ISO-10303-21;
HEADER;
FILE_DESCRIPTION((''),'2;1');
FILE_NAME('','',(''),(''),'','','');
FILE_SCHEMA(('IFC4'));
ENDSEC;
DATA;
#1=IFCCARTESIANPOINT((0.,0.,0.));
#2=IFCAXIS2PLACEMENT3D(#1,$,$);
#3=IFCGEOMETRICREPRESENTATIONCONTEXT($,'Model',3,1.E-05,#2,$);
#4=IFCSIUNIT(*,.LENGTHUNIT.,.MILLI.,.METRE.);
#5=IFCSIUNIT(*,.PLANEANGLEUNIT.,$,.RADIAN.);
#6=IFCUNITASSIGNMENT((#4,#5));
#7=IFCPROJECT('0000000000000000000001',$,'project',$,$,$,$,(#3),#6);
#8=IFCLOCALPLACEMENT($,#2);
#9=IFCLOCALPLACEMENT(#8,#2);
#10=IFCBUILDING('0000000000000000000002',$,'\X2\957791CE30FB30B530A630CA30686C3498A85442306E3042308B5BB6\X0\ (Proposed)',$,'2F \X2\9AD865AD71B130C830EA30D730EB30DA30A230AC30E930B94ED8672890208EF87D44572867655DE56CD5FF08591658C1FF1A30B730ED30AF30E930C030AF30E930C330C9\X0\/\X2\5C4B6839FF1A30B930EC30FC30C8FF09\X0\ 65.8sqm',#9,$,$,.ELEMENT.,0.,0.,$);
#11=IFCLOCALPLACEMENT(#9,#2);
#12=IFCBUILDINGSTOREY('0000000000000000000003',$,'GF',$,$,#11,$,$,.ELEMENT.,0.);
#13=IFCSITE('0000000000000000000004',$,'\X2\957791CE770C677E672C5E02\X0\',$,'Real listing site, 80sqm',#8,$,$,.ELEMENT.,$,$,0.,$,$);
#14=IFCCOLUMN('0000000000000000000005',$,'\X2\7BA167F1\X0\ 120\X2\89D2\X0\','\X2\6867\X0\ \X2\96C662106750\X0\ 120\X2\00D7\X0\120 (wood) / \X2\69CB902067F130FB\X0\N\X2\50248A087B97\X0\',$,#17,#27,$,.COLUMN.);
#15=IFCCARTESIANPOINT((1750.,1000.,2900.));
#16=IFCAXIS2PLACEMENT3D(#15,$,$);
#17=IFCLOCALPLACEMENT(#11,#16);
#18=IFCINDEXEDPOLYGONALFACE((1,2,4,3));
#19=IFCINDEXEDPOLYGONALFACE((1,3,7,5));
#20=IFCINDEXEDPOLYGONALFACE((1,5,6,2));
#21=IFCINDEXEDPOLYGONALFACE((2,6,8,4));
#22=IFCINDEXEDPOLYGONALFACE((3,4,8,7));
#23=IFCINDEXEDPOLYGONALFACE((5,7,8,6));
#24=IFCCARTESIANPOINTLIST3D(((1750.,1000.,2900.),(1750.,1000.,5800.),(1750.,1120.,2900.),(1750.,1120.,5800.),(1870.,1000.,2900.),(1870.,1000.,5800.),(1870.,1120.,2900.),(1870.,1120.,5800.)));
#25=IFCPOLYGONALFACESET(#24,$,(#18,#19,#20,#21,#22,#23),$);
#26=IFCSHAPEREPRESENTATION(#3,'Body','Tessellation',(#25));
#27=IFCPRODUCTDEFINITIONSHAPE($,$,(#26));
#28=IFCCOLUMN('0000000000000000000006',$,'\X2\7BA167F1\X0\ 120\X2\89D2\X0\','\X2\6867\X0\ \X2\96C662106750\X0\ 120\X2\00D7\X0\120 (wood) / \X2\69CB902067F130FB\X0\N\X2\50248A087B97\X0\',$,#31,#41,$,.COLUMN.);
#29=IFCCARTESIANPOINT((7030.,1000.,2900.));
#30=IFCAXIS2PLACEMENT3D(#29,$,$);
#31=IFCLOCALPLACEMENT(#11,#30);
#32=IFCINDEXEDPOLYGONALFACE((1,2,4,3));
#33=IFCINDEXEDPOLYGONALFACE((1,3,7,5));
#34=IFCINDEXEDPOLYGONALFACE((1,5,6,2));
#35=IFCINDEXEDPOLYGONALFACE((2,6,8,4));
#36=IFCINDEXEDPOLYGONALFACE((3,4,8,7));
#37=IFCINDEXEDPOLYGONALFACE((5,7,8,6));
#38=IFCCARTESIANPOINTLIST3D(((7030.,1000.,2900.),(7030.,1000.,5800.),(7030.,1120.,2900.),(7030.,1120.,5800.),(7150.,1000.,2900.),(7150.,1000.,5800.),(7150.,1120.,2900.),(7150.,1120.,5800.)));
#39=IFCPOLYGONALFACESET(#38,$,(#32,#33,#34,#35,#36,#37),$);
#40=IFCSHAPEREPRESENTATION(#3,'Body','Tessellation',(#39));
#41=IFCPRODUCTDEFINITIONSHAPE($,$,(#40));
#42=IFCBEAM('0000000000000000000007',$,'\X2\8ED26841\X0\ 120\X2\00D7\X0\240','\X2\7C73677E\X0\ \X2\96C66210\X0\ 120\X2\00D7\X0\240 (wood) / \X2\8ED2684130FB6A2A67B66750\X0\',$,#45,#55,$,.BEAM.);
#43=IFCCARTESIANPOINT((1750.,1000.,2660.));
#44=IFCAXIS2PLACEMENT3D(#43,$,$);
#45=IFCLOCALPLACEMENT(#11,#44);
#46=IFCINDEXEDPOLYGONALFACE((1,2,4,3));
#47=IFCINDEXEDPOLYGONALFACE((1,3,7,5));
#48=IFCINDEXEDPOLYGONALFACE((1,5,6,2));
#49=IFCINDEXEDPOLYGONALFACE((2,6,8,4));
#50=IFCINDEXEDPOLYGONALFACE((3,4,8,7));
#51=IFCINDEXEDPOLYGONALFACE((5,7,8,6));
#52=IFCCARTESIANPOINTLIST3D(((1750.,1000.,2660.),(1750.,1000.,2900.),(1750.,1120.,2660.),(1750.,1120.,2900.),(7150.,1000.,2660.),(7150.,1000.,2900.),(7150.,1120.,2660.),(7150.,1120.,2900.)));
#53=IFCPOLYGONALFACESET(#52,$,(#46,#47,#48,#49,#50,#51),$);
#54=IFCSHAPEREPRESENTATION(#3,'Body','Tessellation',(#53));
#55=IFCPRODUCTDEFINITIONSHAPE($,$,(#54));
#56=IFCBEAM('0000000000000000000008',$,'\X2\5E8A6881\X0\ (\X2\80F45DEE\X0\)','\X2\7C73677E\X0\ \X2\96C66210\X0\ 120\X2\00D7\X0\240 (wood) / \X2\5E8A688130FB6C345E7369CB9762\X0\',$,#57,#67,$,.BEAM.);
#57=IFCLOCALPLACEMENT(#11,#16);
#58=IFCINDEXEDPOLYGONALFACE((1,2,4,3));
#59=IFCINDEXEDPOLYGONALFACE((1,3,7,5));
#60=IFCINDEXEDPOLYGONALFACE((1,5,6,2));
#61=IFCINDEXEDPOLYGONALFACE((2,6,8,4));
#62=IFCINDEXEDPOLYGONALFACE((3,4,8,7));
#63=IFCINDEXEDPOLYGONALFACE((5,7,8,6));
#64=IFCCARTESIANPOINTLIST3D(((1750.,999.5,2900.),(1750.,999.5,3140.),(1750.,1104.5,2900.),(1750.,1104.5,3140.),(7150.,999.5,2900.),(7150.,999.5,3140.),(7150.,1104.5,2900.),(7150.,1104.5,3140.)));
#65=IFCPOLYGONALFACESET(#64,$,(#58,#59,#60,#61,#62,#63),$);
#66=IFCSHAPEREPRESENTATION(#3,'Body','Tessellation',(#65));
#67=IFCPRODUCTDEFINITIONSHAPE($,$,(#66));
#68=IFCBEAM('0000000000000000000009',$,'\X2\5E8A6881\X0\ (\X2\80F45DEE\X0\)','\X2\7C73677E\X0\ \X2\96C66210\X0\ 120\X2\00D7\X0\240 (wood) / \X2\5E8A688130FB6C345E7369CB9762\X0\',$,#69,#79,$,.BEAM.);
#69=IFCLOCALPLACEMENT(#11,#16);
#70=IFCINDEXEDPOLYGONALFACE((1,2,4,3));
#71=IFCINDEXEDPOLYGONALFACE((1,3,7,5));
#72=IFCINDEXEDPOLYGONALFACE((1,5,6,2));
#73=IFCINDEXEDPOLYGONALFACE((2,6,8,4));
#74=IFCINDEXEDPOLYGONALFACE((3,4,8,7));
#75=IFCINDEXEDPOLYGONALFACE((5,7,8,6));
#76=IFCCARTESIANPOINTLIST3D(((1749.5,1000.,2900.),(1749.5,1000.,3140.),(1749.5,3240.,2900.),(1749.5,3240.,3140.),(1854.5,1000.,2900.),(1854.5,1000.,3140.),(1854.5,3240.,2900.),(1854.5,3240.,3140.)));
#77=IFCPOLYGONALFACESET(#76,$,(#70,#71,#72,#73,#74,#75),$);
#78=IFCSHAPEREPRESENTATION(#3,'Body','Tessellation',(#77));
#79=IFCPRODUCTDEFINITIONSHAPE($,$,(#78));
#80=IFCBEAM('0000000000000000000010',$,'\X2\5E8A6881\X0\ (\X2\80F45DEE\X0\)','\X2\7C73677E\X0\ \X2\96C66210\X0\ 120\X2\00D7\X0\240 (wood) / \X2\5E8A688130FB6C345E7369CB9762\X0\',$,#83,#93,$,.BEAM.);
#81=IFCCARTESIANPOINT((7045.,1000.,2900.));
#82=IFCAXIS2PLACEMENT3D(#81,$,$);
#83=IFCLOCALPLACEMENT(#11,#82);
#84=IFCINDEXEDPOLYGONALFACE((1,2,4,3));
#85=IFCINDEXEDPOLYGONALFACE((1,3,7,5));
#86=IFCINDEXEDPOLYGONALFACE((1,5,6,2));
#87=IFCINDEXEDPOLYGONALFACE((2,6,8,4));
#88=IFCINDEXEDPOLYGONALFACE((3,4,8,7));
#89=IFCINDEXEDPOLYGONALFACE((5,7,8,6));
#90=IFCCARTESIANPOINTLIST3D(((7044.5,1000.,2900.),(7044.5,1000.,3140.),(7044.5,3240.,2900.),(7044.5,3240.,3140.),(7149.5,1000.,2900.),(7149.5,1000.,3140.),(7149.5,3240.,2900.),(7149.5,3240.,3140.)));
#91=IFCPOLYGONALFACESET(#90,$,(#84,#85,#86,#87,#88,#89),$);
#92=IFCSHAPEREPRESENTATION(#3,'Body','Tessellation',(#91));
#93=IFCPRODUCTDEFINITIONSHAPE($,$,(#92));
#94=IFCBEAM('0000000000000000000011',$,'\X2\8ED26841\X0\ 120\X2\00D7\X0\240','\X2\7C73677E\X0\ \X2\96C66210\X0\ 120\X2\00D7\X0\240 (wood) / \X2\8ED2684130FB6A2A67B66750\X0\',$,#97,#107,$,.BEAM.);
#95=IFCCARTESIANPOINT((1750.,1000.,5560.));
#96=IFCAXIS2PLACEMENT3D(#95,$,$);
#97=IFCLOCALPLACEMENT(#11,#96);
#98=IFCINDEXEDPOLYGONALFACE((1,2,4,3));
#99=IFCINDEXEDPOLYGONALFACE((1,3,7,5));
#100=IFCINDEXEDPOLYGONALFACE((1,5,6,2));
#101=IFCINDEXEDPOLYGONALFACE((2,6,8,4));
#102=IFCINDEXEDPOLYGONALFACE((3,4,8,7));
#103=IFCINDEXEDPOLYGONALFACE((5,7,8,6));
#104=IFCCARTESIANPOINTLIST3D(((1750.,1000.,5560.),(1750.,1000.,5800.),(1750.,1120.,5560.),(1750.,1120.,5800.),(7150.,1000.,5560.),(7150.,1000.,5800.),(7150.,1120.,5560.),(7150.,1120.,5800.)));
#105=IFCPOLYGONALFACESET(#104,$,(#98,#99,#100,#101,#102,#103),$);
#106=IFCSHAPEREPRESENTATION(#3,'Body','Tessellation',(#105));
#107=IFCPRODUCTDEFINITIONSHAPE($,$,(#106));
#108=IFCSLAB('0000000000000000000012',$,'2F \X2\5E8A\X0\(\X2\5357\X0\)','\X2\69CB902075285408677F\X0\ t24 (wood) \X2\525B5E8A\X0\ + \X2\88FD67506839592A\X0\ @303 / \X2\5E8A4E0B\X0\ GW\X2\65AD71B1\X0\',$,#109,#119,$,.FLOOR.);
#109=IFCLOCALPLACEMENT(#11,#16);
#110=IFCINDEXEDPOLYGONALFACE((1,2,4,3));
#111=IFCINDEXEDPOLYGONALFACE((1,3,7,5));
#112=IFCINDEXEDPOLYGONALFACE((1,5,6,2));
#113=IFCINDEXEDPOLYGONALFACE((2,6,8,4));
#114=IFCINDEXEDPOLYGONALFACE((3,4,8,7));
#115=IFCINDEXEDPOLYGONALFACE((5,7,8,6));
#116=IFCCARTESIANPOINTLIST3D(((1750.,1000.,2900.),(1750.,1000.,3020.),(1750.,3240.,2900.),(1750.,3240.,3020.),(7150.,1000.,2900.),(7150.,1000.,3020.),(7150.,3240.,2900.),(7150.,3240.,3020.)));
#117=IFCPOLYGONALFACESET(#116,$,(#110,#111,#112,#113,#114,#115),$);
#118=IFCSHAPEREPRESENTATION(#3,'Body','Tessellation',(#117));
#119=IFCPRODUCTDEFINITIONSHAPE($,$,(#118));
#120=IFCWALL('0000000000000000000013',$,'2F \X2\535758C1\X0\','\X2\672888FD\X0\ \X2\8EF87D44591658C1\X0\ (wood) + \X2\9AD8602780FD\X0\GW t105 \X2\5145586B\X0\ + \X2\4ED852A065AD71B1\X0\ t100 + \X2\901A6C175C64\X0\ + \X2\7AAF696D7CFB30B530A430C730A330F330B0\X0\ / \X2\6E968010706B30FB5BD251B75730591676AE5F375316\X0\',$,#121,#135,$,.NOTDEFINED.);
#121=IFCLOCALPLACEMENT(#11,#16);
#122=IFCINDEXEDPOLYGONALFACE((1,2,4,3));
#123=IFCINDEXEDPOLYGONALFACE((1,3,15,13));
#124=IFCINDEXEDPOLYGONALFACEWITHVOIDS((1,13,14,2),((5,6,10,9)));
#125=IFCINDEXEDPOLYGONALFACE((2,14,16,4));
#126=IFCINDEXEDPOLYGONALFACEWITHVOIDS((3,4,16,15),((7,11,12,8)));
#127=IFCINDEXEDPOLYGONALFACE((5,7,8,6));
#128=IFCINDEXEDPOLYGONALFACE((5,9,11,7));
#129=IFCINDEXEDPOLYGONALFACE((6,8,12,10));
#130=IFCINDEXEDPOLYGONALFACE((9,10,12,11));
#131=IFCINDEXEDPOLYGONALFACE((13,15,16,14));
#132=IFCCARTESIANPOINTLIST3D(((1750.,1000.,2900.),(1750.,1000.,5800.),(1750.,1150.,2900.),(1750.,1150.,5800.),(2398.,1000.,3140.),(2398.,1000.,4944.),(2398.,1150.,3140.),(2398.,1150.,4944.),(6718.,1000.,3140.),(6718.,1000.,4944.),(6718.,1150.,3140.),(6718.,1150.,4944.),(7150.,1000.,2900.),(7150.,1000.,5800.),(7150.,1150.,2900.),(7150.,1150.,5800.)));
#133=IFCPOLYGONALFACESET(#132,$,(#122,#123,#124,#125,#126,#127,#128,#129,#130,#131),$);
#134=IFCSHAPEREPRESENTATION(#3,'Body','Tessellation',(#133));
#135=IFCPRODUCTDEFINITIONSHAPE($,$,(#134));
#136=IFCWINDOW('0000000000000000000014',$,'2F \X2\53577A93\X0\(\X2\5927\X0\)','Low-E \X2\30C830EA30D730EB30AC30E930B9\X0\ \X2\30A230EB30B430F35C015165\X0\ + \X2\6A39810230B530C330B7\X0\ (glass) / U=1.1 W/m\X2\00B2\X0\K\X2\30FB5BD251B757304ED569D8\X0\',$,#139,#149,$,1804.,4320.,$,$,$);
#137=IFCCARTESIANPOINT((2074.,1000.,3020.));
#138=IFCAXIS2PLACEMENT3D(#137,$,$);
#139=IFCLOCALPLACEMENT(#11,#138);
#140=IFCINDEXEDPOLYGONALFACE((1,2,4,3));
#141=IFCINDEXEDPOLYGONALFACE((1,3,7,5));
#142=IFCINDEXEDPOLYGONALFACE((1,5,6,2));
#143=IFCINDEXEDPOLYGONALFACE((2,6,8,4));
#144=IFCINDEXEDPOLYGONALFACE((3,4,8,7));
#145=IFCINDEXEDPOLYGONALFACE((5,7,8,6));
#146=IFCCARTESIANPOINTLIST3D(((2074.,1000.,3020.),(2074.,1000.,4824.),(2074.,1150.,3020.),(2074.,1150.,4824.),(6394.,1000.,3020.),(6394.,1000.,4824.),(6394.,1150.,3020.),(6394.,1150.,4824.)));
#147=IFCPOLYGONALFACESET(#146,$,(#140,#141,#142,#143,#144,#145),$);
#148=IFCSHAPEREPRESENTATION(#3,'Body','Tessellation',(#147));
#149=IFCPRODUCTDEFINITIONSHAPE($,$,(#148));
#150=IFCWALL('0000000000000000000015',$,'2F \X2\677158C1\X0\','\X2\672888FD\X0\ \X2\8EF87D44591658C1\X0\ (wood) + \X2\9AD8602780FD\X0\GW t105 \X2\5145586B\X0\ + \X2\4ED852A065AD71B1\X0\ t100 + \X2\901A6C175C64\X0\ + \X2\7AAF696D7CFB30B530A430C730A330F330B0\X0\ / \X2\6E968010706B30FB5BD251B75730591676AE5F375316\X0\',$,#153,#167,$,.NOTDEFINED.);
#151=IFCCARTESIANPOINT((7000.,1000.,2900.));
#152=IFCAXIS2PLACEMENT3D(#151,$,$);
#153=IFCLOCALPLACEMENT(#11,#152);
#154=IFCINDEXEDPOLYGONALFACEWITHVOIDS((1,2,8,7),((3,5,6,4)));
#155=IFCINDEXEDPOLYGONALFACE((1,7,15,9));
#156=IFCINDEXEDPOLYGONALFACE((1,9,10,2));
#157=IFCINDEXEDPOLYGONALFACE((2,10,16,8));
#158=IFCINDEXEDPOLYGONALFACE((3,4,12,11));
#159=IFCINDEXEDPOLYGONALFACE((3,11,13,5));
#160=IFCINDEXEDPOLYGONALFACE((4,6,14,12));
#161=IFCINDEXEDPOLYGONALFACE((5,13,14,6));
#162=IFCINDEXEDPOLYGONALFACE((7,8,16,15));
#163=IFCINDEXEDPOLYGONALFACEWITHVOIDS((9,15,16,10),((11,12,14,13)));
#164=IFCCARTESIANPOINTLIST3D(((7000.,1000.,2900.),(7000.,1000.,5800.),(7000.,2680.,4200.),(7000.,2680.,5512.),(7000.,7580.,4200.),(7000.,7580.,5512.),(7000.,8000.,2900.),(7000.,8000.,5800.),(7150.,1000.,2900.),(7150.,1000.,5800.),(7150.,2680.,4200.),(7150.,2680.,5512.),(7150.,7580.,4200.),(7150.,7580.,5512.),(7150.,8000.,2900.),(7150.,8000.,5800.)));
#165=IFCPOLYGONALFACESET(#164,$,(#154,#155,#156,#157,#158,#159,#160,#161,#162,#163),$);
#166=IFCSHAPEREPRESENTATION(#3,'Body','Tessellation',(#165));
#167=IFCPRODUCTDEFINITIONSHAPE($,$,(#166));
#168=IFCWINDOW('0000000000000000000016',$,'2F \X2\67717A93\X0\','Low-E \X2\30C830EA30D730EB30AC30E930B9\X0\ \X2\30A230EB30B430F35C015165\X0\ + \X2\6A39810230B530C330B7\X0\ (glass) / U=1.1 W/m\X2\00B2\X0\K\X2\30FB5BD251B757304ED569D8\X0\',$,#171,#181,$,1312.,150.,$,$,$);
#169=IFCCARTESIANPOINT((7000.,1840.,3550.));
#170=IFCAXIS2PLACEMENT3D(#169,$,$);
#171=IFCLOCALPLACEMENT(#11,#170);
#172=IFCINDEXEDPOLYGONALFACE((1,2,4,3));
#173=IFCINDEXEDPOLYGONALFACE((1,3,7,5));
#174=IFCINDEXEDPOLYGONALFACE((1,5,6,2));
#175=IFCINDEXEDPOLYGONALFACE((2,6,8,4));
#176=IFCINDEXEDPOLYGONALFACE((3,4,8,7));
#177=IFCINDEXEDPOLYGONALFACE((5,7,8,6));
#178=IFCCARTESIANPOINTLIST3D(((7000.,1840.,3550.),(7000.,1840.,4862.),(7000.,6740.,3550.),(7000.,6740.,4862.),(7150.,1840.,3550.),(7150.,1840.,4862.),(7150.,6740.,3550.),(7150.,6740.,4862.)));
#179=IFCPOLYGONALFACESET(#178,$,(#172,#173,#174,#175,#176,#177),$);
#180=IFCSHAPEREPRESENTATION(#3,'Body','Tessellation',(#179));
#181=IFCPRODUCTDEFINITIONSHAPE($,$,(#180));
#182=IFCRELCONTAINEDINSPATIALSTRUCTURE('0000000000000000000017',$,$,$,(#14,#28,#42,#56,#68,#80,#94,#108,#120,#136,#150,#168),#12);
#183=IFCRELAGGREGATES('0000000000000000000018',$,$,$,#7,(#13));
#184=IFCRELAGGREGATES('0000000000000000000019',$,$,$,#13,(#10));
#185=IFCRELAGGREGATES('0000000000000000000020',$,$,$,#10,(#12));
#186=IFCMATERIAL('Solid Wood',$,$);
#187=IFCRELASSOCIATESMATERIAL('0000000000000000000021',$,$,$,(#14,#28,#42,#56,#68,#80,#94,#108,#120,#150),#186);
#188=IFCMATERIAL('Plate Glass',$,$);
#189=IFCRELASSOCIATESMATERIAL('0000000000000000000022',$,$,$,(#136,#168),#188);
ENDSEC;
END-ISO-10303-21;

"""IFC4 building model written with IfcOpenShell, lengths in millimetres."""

from ifc_helpers import new_model, si_unit, frame, frame_2d, origin, place, context, project, spatial, rectangle, extrude, material, element, fill, save


model = new_model("IFC4")

# Units and contexts
model_context = context("Model", 3, precision=1e-05, world=origin())
ifc_project = project(units=[si_unit("LENGTHUNIT", "METRE", prefix="MILLI"), si_unit("PLANEANGLEUNIT", "RADIAN")], contexts=[model_context])

# Site, building, storey
site_placement = place(None, origin())
site = spatial("IfcSite", under=ifc_project, at=site_placement, Name="長野県松本市", ObjectType="Real listing site, 80sqm", CompositionType="ELEMENT", RefElevation=0.0)
building_placement = place(site_placement, origin())
building = spatial("IfcBuilding", under=site, at=building_placement, Name="長野・サウナと水風呂のある家 (Proposed)", ObjectType="2F 高断熱トリプルペアガラス付木造軸組在来工法（外壁：シロクラダクラッド/屋根：スレート） 65.8sqm", CompositionType="ELEMENT", ElevationOfRefHeight=0.0, ElevationOfTerrain=0.0)
storey_placement = place(building_placement, origin())
storey = spatial("IfcBuildingStorey", under=building, at=storey_placement, Name="GF", CompositionType="ELEMENT", Elevation=0.0)

# Columns
ifc_material_1 = material(Name="Solid Wood")
column_1_placement = place(storey_placement, frame((1750.0, 1000.0, 2900.0)))
element("IfcColumn", 1, at=column_1_placement, inside=storey, material=ifc_material_1, Name="管柱 120角", Description="桧 集成材 120×120 (wood) / 構造柱・N値計算", PredefinedType="COLUMN", context=model_context, shape_type="SweptSolid", body=[
    extrude(rectangle(XDim=120.0, YDim=120.0, at=frame_2d((60.0, 60.0))), frame((1750.0, 1000.0, 2900.0)), (0.0, 0.0, 1.0), 2900.0),
])
column_2_placement = place(storey_placement, frame((7030.0, 1000.0, 2900.0)))
element("IfcColumn", 2, at=column_2_placement, inside=storey, material=ifc_material_1, Name="管柱 120角", Description="桧 集成材 120×120 (wood) / 構造柱・N値計算", PredefinedType="COLUMN", context=model_context, shape_type="SweptSolid", body=[
    extrude(rectangle(XDim=120.0, YDim=120.0, at=frame_2d((60.0, 60.0))), frame((7030.0, 1000.0, 2900.0)), (0.0, 0.0, 1.0), 2900.0),
])

# Beams
beam_1_placement = place(storey_placement, frame((1750.0, 1000.0, 2660.0)))
element("IfcBeam", 3, at=beam_1_placement, inside=storey, material=ifc_material_1, Name="軒桁 120×240", Description="米松 集成 120×240 (wood) / 軒桁・横架材", PredefinedType="BEAM", context=model_context, shape_type="SweptSolid", body=[
    extrude(rectangle(XDim=5400.0, YDim=120.0, at=frame_2d((2700.0, 60.0))), frame((1750.0, 1000.0, 2660.0)), (0.0, 0.0, 1.0), 240.0),
])
beam_2_placement = place(storey_placement, frame((1750.0, 1000.0, 2900.0)))
element("IfcBeam", 4, at=beam_2_placement, inside=storey, material=ifc_material_1, Name="床梁 (胴差)", Description="米松 集成 120×240 (wood) / 床梁・水平構面", PredefinedType="BEAM", context=model_context, shape_type="SweptSolid", body=[
    extrude(rectangle(XDim=5400.0, YDim=105.0, at=frame_2d((2700.0, 52.0))), frame((1750.0, 1000.0, 2900.0)), (0.0, 0.0, 1.0), 240.0),
])
beam_3_placement = place(storey_placement, frame((1750.0, 1000.0, 2900.0)))
element("IfcBeam", 5, at=beam_3_placement, inside=storey, material=ifc_material_1, Name="床梁 (胴差)", Description="米松 集成 120×240 (wood) / 床梁・水平構面", PredefinedType="BEAM", context=model_context, shape_type="SweptSolid", body=[
    extrude(rectangle(XDim=105.0, YDim=2240.0, at=frame_2d((52.0, 1120.0))), frame((1750.0, 1000.0, 2900.0)), (0.0, 0.0, 1.0), 240.0),
])
beam_4_placement = place(storey_placement, frame((7045.0, 1000.0, 2900.0)))
element("IfcBeam", 6, at=beam_4_placement, inside=storey, material=ifc_material_1, Name="床梁 (胴差)", Description="米松 集成 120×240 (wood) / 床梁・水平構面", PredefinedType="BEAM", context=model_context, shape_type="SweptSolid", body=[
    extrude(rectangle(XDim=105.0, YDim=2240.0, at=frame_2d((52.0, 1120.0))), frame((7045.0, 1000.0, 2900.0)), (0.0, 0.0, 1.0), 240.0),
])
beam_5_placement = place(storey_placement, frame((1750.0, 1000.0, 5560.0)))
element("IfcBeam", 7, at=beam_5_placement, inside=storey, material=ifc_material_1, Name="軒桁 120×240", Description="米松 集成 120×240 (wood) / 軒桁・横架材", PredefinedType="BEAM", context=model_context, shape_type="SweptSolid", body=[
    extrude(rectangle(XDim=5400.0, YDim=120.0, at=frame_2d((2700.0, 60.0))), frame((1750.0, 1000.0, 5560.0)), (0.0, 0.0, 1.0), 240.0),
])

# Slab
slab_placement = place(storey_placement, frame((1750.0, 1000.0, 2900.0)))
element("IfcSlab", 8, at=slab_placement, inside=storey, material=ifc_material_1, Name="2F 床(南)", Description="構造用合板 t24 (wood) 剛床 + 製材根太 @303 / 床下 GW断熱", PredefinedType="FLOOR", context=model_context, shape_type="SweptSolid", body=[
    extrude(rectangle(XDim=5400.0, YDim=2240.0, at=frame_2d((2700.0, 1120.0))), frame((1750.0, 1000.0, 2900.0)), (0.0, 0.0, 1.0), 120.0),
])

# Walls, openings, windows
wall_1_placement = place(storey_placement, frame((1750.0, 1000.0, 2900.0)))
wall_1 = element("IfcWall", 9, at=wall_1_placement, inside=storey, material=ifc_material_1, Name="2F 南壁", Description="木製 軸組外壁 (wood) + 高性能GW t105 充填 + 付加断熱 t100 + 通気層 + 窯業系サイディング / 準耐火・寒冷地外皮強化", PredefinedType="NOTDEFINED", context=model_context, shape_type="SweptSolid", body=[
    extrude(rectangle(XDim=5400.0, YDim=150.0, at=frame_2d((2700.0, 75.0))), frame((1750.0, 1000.0, 2900.0)), (0.0, 0.0, 1.0), 2900.0),
])
opening_1_placement = place(storey_placement, frame((2074.0, 1000.0, 3020.0)))
opening_1 = element("IfcOpeningElement", 10, at=opening_1_placement, cuts=wall_1, PredefinedType="NOTDEFINED", context=model_context, shape_type="SweptSolid", body=[
    extrude(rectangle(XDim=4320.0, YDim=150.0, at=frame_2d((2160.0, 75.0))), frame((2074.0, 1000.0, 3020.0)), (0.0, 0.0, 1.0), 1804.0),
])
ifc_material_2 = material(Name="Plate Glass")
window_1_placement = place(storey_placement, frame((2074.0, 1000.0, 3020.0)))
window_1 = element("IfcWindow", 11, at=window_1_placement, inside=storey, material=ifc_material_2, Name="2F 南窓(大)", Description="Low-E トリプルガラス アルゴン封入 + 樹脂サッシ (glass) / U=1.1 W/m²K・寒冷地仕様", OverallHeight=1804.0, OverallWidth=4320.0, context=model_context, shape_type="SweptSolid", body=[
    extrude(rectangle(XDim=4320.0, YDim=150.0, at=frame_2d((2160.0, 75.0))), frame((2074.0, 1000.0, 3020.0)), (0.0, 0.0, 1.0), 1804.0),
])
fill(opening_1, window_1)
wall_2_placement = place(storey_placement, frame((7000.0, 1000.0, 2900.0)))
wall_2 = element("IfcWall", 12, at=wall_2_placement, inside=storey, material=ifc_material_1, Name="2F 東壁", Description="木製 軸組外壁 (wood) + 高性能GW t105 充填 + 付加断熱 t100 + 通気層 + 窯業系サイディング / 準耐火・寒冷地外皮強化", PredefinedType="NOTDEFINED", context=model_context, shape_type="SweptSolid", body=[
    extrude(rectangle(XDim=150.0, YDim=7000.0, at=frame_2d((75.0, 3500.0))), frame((7000.0, 1000.0, 2900.0)), (0.0, 0.0, 1.0), 2900.0),
])
opening_2_placement = place(storey_placement, frame((7000.0, 1840.0, 3550.0)))
opening_2 = element("IfcOpeningElement", 13, at=opening_2_placement, cuts=wall_2, PredefinedType="NOTDEFINED", context=model_context, shape_type="SweptSolid", body=[
    extrude(rectangle(XDim=150.0, YDim=4900.0, at=frame_2d((75.0, 2450.0))), frame((7000.0, 1840.0, 3550.0)), (0.0, 0.0, 1.0), 1312.0),
])
window_2_placement = place(storey_placement, frame((7000.0, 1840.0, 3550.0)))
window_2 = element("IfcWindow", 14, at=window_2_placement, inside=storey, material=ifc_material_2, Name="2F 東窓", Description="Low-E トリプルガラス アルゴン封入 + 樹脂サッシ (glass) / U=1.1 W/m²K・寒冷地仕様", OverallHeight=1312.0, OverallWidth=150.0, context=model_context, shape_type="SweptSolid", body=[
    extrude(rectangle(XDim=150.0, YDim=4900.0, at=frame_2d((75.0, 2450.0))), frame((7000.0, 1840.0, 3550.0)), (0.0, 0.0, 1.0), 1312.0),
])
fill(opening_2, window_2)

save(model, "model.ifc")
